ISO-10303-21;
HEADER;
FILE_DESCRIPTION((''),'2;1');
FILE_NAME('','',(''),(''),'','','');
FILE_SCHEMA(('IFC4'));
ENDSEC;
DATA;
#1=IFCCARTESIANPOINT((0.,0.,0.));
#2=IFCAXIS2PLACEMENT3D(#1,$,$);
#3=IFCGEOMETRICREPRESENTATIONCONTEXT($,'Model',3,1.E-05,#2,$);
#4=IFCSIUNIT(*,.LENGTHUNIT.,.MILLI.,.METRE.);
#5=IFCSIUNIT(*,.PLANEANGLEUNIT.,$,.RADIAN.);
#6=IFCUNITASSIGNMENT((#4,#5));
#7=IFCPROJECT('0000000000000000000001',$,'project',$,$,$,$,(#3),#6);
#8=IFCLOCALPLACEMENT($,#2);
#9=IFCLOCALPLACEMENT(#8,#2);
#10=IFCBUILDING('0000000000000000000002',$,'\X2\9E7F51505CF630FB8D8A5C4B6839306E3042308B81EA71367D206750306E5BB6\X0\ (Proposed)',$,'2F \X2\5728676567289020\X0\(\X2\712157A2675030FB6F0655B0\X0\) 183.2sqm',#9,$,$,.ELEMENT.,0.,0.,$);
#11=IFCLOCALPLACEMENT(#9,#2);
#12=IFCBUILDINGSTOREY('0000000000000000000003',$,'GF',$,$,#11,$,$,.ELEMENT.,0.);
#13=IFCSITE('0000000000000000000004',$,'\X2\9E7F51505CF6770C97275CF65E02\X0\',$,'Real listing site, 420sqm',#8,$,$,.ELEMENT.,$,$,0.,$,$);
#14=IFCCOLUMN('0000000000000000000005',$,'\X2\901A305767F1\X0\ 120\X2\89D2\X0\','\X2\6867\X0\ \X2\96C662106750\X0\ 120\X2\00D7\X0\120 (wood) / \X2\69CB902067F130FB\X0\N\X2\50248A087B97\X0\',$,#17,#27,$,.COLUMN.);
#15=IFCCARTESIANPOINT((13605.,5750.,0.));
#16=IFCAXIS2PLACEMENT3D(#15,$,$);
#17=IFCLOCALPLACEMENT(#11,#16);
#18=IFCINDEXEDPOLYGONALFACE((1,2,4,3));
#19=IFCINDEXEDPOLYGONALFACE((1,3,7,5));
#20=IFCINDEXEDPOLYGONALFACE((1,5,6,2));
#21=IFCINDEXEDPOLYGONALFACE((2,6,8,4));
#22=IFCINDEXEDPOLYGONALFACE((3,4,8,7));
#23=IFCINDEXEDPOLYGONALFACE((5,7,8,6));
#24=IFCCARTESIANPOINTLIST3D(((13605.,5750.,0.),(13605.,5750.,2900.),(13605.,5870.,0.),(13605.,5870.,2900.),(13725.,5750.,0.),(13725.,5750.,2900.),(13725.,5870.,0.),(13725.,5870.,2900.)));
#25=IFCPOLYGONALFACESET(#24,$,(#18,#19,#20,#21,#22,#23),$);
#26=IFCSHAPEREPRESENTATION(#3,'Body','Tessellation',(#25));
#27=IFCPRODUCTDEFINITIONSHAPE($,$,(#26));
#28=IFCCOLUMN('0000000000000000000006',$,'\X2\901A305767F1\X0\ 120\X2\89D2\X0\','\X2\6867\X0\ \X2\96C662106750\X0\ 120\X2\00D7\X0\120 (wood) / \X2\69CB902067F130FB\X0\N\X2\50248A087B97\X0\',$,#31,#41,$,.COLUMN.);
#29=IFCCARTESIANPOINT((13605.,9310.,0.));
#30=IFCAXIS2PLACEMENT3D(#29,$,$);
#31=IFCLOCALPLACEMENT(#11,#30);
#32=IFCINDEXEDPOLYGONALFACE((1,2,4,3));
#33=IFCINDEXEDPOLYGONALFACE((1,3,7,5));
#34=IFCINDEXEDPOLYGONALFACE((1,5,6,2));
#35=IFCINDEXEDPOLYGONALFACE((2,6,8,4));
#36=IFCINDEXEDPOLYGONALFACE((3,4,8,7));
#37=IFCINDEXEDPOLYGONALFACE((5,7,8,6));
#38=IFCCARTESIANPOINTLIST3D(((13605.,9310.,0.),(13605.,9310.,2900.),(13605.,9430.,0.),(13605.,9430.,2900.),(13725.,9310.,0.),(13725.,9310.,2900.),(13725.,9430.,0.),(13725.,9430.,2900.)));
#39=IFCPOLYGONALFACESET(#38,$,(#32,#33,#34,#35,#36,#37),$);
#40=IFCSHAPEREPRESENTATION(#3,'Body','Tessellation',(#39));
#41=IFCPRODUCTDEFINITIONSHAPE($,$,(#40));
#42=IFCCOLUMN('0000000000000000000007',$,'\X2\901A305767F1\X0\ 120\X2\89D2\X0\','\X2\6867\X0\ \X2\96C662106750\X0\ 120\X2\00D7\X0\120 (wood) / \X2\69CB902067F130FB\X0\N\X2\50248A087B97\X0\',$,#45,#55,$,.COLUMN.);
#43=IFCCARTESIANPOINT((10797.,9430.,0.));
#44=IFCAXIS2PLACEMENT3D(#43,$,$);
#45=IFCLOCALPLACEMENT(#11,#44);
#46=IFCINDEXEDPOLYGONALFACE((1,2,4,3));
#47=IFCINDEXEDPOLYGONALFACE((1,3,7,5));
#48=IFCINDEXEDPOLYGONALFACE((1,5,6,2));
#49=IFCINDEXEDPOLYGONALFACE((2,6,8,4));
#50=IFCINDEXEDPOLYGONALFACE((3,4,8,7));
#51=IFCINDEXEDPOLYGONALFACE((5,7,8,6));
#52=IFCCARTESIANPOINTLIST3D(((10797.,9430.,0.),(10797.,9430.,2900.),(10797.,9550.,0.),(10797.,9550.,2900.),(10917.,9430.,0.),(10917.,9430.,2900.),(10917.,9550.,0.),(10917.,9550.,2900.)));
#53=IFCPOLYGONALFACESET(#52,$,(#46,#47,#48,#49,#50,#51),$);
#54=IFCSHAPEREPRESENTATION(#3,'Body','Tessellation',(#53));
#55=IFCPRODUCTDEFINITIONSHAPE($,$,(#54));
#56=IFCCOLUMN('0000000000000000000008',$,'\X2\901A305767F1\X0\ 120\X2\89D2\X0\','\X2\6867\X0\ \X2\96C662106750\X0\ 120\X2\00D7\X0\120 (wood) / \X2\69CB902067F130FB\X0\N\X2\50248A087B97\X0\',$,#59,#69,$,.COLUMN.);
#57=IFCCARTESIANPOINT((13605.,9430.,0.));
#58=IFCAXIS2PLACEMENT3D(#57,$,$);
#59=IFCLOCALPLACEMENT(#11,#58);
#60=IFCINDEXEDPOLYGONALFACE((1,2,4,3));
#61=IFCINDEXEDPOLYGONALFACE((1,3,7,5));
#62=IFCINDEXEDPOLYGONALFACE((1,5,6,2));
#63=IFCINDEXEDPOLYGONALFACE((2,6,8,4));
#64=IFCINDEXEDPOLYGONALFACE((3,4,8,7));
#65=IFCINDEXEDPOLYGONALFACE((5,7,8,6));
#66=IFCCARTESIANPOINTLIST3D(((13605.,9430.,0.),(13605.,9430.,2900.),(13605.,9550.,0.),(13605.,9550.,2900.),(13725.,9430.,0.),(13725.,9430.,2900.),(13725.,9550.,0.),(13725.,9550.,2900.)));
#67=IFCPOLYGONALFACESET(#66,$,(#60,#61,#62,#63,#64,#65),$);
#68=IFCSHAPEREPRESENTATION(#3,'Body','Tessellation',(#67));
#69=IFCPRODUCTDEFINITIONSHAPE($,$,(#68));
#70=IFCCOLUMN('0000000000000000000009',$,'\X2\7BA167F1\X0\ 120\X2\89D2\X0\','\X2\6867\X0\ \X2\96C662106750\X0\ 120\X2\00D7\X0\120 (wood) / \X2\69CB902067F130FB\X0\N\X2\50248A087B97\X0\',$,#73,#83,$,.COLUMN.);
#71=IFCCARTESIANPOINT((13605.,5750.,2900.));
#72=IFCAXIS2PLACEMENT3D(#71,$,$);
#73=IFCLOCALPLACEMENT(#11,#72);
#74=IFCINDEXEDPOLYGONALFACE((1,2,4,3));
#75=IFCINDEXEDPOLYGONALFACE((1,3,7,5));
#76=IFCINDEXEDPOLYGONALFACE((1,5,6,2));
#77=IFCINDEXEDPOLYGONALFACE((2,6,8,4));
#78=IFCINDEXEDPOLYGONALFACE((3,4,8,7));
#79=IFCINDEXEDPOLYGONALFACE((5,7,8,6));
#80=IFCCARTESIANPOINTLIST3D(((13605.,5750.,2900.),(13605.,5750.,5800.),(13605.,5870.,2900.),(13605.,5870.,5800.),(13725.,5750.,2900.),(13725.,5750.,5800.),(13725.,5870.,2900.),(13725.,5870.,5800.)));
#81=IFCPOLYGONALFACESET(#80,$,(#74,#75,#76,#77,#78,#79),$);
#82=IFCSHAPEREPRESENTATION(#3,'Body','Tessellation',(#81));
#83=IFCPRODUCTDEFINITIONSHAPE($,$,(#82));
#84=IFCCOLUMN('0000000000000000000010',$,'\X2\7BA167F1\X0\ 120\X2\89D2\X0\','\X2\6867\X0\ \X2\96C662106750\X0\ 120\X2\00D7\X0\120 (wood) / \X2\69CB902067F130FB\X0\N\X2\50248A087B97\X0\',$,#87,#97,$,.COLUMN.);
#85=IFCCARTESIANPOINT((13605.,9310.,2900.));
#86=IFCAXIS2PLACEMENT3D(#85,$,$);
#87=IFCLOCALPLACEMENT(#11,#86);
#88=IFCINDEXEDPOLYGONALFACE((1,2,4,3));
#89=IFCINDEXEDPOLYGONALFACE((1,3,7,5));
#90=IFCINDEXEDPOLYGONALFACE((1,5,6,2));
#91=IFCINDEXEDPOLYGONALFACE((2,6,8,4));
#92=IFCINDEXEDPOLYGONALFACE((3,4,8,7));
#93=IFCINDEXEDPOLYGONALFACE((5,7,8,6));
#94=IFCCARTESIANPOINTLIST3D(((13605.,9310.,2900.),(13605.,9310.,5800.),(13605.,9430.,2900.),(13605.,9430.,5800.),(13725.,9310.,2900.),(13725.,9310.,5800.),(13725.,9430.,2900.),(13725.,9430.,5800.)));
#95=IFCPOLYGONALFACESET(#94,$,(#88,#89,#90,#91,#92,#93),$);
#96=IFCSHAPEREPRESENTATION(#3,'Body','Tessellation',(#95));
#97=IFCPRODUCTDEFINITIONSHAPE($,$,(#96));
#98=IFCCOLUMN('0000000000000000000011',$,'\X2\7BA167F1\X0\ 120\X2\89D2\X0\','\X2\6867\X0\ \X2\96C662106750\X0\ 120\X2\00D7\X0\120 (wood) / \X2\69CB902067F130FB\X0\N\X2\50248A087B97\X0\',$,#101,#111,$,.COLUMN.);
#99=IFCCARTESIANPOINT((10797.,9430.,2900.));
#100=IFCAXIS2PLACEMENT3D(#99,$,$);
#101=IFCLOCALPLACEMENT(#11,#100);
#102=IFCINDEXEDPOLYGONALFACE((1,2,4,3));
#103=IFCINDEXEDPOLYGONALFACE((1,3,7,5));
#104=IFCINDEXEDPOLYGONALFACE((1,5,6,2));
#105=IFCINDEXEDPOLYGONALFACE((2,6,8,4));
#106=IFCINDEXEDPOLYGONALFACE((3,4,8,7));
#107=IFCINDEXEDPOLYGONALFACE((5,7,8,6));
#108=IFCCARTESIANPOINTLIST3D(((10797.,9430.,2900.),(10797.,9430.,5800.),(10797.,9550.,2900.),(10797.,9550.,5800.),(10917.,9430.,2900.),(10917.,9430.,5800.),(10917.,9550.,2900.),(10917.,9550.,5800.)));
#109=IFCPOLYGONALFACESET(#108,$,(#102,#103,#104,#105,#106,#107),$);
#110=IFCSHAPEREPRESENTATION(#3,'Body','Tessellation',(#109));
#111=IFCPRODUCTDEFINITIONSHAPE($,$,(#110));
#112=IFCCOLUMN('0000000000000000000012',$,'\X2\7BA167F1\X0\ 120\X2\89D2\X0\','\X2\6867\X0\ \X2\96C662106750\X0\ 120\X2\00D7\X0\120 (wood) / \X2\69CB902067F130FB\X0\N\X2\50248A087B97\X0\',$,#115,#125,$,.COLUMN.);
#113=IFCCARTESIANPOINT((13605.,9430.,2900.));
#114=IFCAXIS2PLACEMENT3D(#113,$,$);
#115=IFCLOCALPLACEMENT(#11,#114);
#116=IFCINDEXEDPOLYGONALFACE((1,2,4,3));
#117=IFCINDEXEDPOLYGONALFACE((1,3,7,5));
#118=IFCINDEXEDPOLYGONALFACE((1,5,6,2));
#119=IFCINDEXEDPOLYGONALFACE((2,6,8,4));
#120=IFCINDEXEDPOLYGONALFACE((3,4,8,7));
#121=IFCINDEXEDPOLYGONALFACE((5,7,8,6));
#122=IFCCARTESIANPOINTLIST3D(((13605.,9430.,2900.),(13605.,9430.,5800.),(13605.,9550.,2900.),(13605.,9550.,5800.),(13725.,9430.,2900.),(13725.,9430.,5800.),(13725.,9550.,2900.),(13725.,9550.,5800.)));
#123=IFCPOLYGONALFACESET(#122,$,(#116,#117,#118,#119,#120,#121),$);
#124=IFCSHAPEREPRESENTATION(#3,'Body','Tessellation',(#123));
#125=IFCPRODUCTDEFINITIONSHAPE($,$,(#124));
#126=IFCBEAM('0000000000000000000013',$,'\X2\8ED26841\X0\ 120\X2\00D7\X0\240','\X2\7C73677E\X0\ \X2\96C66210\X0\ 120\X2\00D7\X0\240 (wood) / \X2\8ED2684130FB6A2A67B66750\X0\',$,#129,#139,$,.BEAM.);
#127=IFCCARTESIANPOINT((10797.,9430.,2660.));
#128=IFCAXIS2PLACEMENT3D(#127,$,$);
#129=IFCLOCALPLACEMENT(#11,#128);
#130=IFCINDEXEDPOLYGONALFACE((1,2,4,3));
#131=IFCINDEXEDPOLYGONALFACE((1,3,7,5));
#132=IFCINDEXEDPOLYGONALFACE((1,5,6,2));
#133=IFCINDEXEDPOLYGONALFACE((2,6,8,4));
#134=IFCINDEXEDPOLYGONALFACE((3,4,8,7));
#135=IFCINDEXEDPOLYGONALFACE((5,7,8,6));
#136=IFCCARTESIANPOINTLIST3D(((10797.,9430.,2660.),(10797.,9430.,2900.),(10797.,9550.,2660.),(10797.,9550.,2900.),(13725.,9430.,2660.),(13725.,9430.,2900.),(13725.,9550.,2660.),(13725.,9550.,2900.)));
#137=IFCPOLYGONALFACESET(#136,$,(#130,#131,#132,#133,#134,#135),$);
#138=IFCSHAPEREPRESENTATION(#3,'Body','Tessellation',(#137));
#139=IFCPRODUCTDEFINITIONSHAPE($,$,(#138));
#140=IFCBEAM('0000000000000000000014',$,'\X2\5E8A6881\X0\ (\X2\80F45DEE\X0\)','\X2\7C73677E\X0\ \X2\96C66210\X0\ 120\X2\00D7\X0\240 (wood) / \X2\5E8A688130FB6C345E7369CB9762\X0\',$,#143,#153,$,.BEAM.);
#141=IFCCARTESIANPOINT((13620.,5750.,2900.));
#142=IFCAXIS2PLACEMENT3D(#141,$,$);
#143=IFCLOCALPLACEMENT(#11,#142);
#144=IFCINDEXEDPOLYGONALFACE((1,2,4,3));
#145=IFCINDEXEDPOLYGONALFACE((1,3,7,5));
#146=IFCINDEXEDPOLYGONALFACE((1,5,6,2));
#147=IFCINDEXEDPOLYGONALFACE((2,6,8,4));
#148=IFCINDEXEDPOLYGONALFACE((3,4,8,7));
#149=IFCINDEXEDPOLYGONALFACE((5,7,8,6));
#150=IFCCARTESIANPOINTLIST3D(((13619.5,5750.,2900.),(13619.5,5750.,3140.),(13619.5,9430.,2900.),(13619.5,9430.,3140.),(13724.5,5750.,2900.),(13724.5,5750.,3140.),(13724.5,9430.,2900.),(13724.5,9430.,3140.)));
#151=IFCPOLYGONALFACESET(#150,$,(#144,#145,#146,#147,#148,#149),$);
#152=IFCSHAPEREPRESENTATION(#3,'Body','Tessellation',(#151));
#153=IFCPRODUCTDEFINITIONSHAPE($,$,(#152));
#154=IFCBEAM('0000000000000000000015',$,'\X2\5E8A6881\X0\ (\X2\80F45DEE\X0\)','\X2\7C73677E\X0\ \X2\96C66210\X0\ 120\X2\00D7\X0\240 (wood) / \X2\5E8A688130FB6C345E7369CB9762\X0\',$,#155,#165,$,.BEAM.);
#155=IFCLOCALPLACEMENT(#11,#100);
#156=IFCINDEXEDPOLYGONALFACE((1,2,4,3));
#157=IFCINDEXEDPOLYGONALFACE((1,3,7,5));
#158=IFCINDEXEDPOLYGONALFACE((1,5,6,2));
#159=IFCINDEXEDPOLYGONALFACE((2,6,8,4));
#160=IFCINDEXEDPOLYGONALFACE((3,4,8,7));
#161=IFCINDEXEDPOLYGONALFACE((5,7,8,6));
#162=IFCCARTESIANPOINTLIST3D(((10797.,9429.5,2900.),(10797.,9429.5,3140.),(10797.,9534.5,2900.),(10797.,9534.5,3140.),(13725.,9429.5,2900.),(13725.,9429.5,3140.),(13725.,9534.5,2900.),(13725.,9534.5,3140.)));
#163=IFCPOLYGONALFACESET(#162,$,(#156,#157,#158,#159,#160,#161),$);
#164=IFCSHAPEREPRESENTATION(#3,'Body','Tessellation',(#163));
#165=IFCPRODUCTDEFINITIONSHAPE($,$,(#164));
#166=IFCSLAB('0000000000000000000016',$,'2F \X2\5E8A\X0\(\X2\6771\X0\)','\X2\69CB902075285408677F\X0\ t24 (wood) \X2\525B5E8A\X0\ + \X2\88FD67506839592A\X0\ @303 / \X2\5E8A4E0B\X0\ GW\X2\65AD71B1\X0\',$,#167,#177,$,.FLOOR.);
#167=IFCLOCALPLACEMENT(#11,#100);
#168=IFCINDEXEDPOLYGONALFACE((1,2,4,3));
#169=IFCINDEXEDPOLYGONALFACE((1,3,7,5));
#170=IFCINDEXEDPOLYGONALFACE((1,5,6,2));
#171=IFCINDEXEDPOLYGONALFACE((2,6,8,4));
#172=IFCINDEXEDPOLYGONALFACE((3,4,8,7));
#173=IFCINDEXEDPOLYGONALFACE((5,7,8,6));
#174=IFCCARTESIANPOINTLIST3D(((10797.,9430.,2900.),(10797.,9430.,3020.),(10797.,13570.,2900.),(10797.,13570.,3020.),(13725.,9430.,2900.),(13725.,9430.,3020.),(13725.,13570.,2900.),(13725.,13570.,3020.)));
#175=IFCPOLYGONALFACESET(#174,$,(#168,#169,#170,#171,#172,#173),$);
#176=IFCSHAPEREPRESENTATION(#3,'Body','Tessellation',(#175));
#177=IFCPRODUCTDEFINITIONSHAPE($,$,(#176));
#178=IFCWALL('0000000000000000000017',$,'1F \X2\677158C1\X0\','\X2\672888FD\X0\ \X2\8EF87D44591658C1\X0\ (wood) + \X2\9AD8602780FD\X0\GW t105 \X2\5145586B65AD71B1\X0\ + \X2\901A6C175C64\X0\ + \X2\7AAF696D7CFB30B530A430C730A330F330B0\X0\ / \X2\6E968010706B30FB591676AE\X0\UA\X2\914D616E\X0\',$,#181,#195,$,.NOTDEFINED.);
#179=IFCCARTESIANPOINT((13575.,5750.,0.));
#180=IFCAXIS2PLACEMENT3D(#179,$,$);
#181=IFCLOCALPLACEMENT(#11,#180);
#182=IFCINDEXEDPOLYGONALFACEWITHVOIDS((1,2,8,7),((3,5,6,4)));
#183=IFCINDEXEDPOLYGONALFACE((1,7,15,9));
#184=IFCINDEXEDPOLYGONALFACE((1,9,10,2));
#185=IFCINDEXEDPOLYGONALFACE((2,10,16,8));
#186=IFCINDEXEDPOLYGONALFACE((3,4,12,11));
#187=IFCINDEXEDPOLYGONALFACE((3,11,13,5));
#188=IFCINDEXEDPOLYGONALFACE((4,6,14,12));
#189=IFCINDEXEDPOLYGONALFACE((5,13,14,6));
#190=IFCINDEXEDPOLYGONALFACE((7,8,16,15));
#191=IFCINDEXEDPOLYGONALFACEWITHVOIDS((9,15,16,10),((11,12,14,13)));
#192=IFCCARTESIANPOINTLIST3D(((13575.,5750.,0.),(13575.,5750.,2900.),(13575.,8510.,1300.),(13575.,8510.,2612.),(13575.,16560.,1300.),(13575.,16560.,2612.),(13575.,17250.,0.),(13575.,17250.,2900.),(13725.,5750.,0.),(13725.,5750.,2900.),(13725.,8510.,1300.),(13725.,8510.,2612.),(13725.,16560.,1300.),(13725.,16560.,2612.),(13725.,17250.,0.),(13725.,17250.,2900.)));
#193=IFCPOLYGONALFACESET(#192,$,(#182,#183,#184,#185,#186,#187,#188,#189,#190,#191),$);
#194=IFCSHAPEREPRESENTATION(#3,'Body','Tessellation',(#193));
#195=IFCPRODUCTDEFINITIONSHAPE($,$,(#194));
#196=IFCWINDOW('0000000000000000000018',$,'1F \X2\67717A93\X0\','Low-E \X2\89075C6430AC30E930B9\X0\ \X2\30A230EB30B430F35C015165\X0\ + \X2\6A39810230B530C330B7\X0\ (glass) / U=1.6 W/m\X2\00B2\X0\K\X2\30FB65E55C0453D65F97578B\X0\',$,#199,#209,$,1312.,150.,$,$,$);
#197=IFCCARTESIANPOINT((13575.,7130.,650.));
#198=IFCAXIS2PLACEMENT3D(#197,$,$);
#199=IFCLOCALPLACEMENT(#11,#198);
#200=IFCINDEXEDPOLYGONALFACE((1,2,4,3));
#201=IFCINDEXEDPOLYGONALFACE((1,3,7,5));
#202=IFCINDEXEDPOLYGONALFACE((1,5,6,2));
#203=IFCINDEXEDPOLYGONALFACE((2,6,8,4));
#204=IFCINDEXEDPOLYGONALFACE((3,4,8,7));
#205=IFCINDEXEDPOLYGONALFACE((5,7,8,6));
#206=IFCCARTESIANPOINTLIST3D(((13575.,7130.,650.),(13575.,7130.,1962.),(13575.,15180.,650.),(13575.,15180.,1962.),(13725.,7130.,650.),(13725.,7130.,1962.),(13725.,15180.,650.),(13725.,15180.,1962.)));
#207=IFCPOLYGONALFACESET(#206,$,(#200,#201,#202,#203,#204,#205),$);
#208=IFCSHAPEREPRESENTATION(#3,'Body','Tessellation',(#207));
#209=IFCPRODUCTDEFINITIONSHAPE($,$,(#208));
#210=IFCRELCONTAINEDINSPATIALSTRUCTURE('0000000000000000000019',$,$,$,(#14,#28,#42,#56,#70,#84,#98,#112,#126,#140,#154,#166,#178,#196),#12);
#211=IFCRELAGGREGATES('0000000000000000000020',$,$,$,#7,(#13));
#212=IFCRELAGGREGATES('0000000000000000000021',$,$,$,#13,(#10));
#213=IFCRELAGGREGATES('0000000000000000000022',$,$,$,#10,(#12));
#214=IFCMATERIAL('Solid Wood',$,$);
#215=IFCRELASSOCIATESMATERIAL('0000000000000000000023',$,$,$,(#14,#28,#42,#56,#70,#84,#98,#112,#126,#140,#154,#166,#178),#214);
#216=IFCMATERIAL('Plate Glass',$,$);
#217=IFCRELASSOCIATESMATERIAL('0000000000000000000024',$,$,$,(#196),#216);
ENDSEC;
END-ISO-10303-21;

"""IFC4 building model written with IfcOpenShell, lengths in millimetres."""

from ifc_helpers import new_model, si_unit, frame, frame_2d, origin, place, context, project, spatial, rectangle, extrude, material, element, fill, save


model = new_model("IFC4")

# Units and contexts
model_context = context("Model", 3, precision=1e-05, world=origin())
ifc_project = project(units=[si_unit("LENGTHUNIT", "METRE", prefix="MILLI"), si_unit("PLANEANGLEUNIT", "RADIAN")], contexts=[model_context])

# Site, building, storey
site_placement = place(None, origin())
site = spatial("IfcSite", under=ifc_project, at=site_placement, Name="鹿児島県霧島市", ObjectType="Real listing site, 420sqm", CompositionType="ELEMENT", RefElevation=0.0)
building_placement = place(site_placement, origin())
building = spatial("IfcBuilding", under=site, at=building_placement, Name="鹿児島・越屋根のある自然素材の家 (Proposed)", ObjectType="2F 在来木造(無垢材・漆喰) 183.2sqm", CompositionType="ELEMENT", ElevationOfRefHeight=0.0, ElevationOfTerrain=0.0)
storey_placement = place(building_placement, origin())
storey = spatial("IfcBuildingStorey", under=building, at=storey_placement, Name="GF", CompositionType="ELEMENT", Elevation=0.0)

# Columns
ifc_material_1 = material(Name="Solid Wood")
column_1_placement = place(storey_placement, frame((13605.0, 5750.0, 0.0)))
element("IfcColumn", 1, at=column_1_placement, inside=storey, material=ifc_material_1, Name="通し柱 120角", Description="桧 集成材 120×120 (wood) / 構造柱・N値計算", PredefinedType="COLUMN", context=model_context, shape_type="SweptSolid", body=[
    extrude(rectangle(XDim=120.0, YDim=120.0, at=frame_2d((60.0, 60.0))), frame((13605.0, 5750.0, 0.0)), (0.0, 0.0, 1.0), 2900.0),
])
column_2_placement = place(storey_placement, frame((13605.0, 9310.0, 0.0)))
element("IfcColumn", 2, at=column_2_placement, inside=storey, material=ifc_material_1, Name="通し柱 120角", Description="桧 集成材 120×120 (wood) / 構造柱・N値計算", PredefinedType="COLUMN", context=model_context, shape_type="SweptSolid", body=[
    extrude(rectangle(XDim=120.0, YDim=120.0, at=frame_2d((60.0, 60.0))), frame((13605.0, 9310.0, 0.0)), (0.0, 0.0, 1.0), 2900.0),
])
column_3_placement = place(storey_placement, frame((10797.0, 9430.0, 0.0)))
element("IfcColumn", 3, at=column_3_placement, inside=storey, material=ifc_material_1, Name="通し柱 120角", Description="桧 集成材 120×120 (wood) / 構造柱・N値計算", PredefinedType="COLUMN", context=model_context, shape_type="SweptSolid", body=[
    extrude(rectangle(XDim=120.0, YDim=120.0, at=frame_2d((60.0, 60.0))), frame((10797.0, 9430.0, 0.0)), (0.0, 0.0, 1.0), 2900.0),
])
column_4_placement = place(storey_placement, frame((13605.0, 9430.0, 0.0)))
element("IfcColumn", 4, at=column_4_placement, inside=storey, material=ifc_material_1, Name="通し柱 120角", Description="桧 集成材 120×120 (wood) / 構造柱・N値計算", PredefinedType="COLUMN", context=model_context, shape_type="SweptSolid", body=[
    extrude(rectangle(XDim=120.0, YDim=120.0, at=frame_2d((60.0, 60.0))), frame((13605.0, 9430.0, 0.0)), (0.0, 0.0, 1.0), 2900.0),
])
column_5_placement = place(storey_placement, frame((13605.0, 5750.0, 2900.0)))
element("IfcColumn", 5, at=column_5_placement, inside=storey, material=ifc_material_1, Name="管柱 120角", Description="桧 集成材 120×120 (wood) / 構造柱・N値計算", PredefinedType="COLUMN", context=model_context, shape_type="SweptSolid", body=[
    extrude(rectangle(XDim=120.0, YDim=120.0, at=frame_2d((60.0, 60.0))), frame((13605.0, 5750.0, 2900.0)), (0.0, 0.0, 1.0), 2900.0),
])
column_6_placement = place(storey_placement, frame((13605.0, 9310.0, 2900.0)))
element("IfcColumn", 6, at=column_6_placement, inside=storey, material=ifc_material_1, Name="管柱 120角", Description="桧 集成材 120×120 (wood) / 構造柱・N値計算", PredefinedType="COLUMN", context=model_context, shape_type="SweptSolid", body=[
    extrude(rectangle(XDim=120.0, YDim=120.0, at=frame_2d((60.0, 60.0))), frame((13605.0, 9310.0, 2900.0)), (0.0, 0.0, 1.0), 2900.0),
])
column_7_placement = place(storey_placement, frame((10797.0, 9430.0, 2900.0)))
element("IfcColumn", 7, at=column_7_placement, inside=storey, material=ifc_material_1, Name="管柱 120角", Description="桧 集成材 120×120 (wood) / 構造柱・N値計算", PredefinedType="COLUMN", context=model_context, shape_type="SweptSolid", body=[
    extrude(rectangle(XDim=120.0, YDim=120.0, at=frame_2d((60.0, 60.0))), frame((10797.0, 9430.0, 2900.0)), (0.0, 0.0, 1.0), 2900.0),
])
column_8_placement = place(storey_placement, frame((13605.0, 9430.0, 2900.0)))
element("IfcColumn", 8, at=column_8_placement, inside=storey, material=ifc_material_1, Name="管柱 120角", Description="桧 集成材 120×120 (wood) / 構造柱・N値計算", PredefinedType="COLUMN", context=model_context, shape_type="SweptSolid", body=[
    extrude(rectangle(XDim=120.0, YDim=120.0, at=frame_2d((60.0, 60.0))), frame((13605.0, 9430.0, 2900.0)), (0.0, 0.0, 1.0), 2900.0),
])

# Beams
beam_1_placement = place(storey_placement, frame((10797.0, 9430.0, 2660.0)))
element("IfcBeam", 9, at=beam_1_placement, inside=storey, material=ifc_material_1, Name="軒桁 120×240", Description="米松 集成 120×240 (wood) / 軒桁・横架材", PredefinedType="BEAM", context=model_context, shape_type="SweptSolid", body=[
    extrude(rectangle(XDim=2928.0, YDim=120.0, at=frame_2d((1464.0, 60.0))), frame((10797.0, 9430.0, 2660.0)), (0.0, 0.0, 1.0), 240.0),
])
beam_2_placement = place(storey_placement, frame((13620.0, 5750.0, 2900.0)))
element("IfcBeam", 10, at=beam_2_placement, inside=storey, material=ifc_material_1, Name="床梁 (胴差)", Description="米松 集成 120×240 (wood) / 床梁・水平構面", PredefinedType="BEAM", context=model_context, shape_type="SweptSolid", body=[
    extrude(rectangle(XDim=105.0, YDim=3680.0, at=frame_2d((52.0, 1840.0))), frame((13620.0, 5750.0, 2900.0)), (0.0, 0.0, 1.0), 240.0),
])
beam_3_placement = place(storey_placement, frame((10797.0, 9430.0, 2900.0)))
element("IfcBeam", 11, at=beam_3_placement, inside=storey, material=ifc_material_1, Name="床梁 (胴差)", Description="米松 集成 120×240 (wood) / 床梁・水平構面", PredefinedType="BEAM", context=model_context, shape_type="SweptSolid", body=[
    extrude(rectangle(XDim=2928.0, YDim=105.0, at=frame_2d((1464.0, 52.0))), frame((10797.0, 9430.0, 2900.0)), (0.0, 0.0, 1.0), 240.0),
])

# Slab
slab_placement = place(storey_placement, frame((10797.0, 9430.0, 2900.0)))
element("IfcSlab", 12, at=slab_placement, inside=storey, material=ifc_material_1, Name="2F 床(東)", Description="構造用合板 t24 (wood) 剛床 + 製材根太 @303 / 床下 GW断熱", PredefinedType="FLOOR", context=model_context, shape_type="SweptSolid", body=[
    extrude(rectangle(XDim=2928.0, YDim=4140.0, at=frame_2d((1464.0, 2070.0))), frame((10797.0, 9430.0, 2900.0)), (0.0, 0.0, 1.0), 120.0),
])

# Wall, opening, window
wall_1_placement = place(storey_placement, frame((13575.0, 5750.0, 0.0)))
wall_1 = element("IfcWall", 13, at=wall_1_placement, inside=storey, material=ifc_material_1, Name="1F 東壁", Description="木製 軸組外壁 (wood) + 高性能GW t105 充填断熱 + 通気層 + 窯業系サイディング / 準耐火・外皮UA配慮", PredefinedType="NOTDEFINED", context=model_context, shape_type="SweptSolid", body=[
    extrude(rectangle(XDim=150.0, YDim=11500.0, at=frame_2d((75.0, 5750.0))), frame((13575.0, 5750.0, 0.0)), (0.0, 0.0, 1.0), 2900.0),
])
opening_1_placement = place(storey_placement, frame((13575.0, 7130.0, 650.0)))
opening_1 = element("IfcOpeningElement", 14, at=opening_1_placement, cuts=wall_1, PredefinedType="NOTDEFINED", context=model_context, shape_type="SweptSolid", body=[
    extrude(rectangle(XDim=150.0, YDim=8050.0, at=frame_2d((75.0, 4025.0))), frame((13575.0, 7130.0, 650.0)), (0.0, 0.0, 1.0), 1312.0),
])
ifc_material_2 = material(Name="Plate Glass")
window_1_placement = place(storey_placement, frame((13575.0, 7130.0, 650.0)))
window_1 = element("IfcWindow", 15, at=window_1_placement, inside=storey, material=ifc_material_2, Name="1F 東窓", Description="Low-E 複層ガラス アルゴン封入 + 樹脂サッシ (glass) / U=1.6 W/m²K・日射取得型", OverallHeight=1312.0, OverallWidth=150.0, context=model_context, shape_type="SweptSolid", body=[
    extrude(rectangle(XDim=150.0, YDim=8050.0, at=frame_2d((75.0, 4025.0))), frame((13575.0, 7130.0, 650.0)), (0.0, 0.0, 1.0), 1312.0),
])
fill(opening_1, window_1)

save(model, "model.ifc")
